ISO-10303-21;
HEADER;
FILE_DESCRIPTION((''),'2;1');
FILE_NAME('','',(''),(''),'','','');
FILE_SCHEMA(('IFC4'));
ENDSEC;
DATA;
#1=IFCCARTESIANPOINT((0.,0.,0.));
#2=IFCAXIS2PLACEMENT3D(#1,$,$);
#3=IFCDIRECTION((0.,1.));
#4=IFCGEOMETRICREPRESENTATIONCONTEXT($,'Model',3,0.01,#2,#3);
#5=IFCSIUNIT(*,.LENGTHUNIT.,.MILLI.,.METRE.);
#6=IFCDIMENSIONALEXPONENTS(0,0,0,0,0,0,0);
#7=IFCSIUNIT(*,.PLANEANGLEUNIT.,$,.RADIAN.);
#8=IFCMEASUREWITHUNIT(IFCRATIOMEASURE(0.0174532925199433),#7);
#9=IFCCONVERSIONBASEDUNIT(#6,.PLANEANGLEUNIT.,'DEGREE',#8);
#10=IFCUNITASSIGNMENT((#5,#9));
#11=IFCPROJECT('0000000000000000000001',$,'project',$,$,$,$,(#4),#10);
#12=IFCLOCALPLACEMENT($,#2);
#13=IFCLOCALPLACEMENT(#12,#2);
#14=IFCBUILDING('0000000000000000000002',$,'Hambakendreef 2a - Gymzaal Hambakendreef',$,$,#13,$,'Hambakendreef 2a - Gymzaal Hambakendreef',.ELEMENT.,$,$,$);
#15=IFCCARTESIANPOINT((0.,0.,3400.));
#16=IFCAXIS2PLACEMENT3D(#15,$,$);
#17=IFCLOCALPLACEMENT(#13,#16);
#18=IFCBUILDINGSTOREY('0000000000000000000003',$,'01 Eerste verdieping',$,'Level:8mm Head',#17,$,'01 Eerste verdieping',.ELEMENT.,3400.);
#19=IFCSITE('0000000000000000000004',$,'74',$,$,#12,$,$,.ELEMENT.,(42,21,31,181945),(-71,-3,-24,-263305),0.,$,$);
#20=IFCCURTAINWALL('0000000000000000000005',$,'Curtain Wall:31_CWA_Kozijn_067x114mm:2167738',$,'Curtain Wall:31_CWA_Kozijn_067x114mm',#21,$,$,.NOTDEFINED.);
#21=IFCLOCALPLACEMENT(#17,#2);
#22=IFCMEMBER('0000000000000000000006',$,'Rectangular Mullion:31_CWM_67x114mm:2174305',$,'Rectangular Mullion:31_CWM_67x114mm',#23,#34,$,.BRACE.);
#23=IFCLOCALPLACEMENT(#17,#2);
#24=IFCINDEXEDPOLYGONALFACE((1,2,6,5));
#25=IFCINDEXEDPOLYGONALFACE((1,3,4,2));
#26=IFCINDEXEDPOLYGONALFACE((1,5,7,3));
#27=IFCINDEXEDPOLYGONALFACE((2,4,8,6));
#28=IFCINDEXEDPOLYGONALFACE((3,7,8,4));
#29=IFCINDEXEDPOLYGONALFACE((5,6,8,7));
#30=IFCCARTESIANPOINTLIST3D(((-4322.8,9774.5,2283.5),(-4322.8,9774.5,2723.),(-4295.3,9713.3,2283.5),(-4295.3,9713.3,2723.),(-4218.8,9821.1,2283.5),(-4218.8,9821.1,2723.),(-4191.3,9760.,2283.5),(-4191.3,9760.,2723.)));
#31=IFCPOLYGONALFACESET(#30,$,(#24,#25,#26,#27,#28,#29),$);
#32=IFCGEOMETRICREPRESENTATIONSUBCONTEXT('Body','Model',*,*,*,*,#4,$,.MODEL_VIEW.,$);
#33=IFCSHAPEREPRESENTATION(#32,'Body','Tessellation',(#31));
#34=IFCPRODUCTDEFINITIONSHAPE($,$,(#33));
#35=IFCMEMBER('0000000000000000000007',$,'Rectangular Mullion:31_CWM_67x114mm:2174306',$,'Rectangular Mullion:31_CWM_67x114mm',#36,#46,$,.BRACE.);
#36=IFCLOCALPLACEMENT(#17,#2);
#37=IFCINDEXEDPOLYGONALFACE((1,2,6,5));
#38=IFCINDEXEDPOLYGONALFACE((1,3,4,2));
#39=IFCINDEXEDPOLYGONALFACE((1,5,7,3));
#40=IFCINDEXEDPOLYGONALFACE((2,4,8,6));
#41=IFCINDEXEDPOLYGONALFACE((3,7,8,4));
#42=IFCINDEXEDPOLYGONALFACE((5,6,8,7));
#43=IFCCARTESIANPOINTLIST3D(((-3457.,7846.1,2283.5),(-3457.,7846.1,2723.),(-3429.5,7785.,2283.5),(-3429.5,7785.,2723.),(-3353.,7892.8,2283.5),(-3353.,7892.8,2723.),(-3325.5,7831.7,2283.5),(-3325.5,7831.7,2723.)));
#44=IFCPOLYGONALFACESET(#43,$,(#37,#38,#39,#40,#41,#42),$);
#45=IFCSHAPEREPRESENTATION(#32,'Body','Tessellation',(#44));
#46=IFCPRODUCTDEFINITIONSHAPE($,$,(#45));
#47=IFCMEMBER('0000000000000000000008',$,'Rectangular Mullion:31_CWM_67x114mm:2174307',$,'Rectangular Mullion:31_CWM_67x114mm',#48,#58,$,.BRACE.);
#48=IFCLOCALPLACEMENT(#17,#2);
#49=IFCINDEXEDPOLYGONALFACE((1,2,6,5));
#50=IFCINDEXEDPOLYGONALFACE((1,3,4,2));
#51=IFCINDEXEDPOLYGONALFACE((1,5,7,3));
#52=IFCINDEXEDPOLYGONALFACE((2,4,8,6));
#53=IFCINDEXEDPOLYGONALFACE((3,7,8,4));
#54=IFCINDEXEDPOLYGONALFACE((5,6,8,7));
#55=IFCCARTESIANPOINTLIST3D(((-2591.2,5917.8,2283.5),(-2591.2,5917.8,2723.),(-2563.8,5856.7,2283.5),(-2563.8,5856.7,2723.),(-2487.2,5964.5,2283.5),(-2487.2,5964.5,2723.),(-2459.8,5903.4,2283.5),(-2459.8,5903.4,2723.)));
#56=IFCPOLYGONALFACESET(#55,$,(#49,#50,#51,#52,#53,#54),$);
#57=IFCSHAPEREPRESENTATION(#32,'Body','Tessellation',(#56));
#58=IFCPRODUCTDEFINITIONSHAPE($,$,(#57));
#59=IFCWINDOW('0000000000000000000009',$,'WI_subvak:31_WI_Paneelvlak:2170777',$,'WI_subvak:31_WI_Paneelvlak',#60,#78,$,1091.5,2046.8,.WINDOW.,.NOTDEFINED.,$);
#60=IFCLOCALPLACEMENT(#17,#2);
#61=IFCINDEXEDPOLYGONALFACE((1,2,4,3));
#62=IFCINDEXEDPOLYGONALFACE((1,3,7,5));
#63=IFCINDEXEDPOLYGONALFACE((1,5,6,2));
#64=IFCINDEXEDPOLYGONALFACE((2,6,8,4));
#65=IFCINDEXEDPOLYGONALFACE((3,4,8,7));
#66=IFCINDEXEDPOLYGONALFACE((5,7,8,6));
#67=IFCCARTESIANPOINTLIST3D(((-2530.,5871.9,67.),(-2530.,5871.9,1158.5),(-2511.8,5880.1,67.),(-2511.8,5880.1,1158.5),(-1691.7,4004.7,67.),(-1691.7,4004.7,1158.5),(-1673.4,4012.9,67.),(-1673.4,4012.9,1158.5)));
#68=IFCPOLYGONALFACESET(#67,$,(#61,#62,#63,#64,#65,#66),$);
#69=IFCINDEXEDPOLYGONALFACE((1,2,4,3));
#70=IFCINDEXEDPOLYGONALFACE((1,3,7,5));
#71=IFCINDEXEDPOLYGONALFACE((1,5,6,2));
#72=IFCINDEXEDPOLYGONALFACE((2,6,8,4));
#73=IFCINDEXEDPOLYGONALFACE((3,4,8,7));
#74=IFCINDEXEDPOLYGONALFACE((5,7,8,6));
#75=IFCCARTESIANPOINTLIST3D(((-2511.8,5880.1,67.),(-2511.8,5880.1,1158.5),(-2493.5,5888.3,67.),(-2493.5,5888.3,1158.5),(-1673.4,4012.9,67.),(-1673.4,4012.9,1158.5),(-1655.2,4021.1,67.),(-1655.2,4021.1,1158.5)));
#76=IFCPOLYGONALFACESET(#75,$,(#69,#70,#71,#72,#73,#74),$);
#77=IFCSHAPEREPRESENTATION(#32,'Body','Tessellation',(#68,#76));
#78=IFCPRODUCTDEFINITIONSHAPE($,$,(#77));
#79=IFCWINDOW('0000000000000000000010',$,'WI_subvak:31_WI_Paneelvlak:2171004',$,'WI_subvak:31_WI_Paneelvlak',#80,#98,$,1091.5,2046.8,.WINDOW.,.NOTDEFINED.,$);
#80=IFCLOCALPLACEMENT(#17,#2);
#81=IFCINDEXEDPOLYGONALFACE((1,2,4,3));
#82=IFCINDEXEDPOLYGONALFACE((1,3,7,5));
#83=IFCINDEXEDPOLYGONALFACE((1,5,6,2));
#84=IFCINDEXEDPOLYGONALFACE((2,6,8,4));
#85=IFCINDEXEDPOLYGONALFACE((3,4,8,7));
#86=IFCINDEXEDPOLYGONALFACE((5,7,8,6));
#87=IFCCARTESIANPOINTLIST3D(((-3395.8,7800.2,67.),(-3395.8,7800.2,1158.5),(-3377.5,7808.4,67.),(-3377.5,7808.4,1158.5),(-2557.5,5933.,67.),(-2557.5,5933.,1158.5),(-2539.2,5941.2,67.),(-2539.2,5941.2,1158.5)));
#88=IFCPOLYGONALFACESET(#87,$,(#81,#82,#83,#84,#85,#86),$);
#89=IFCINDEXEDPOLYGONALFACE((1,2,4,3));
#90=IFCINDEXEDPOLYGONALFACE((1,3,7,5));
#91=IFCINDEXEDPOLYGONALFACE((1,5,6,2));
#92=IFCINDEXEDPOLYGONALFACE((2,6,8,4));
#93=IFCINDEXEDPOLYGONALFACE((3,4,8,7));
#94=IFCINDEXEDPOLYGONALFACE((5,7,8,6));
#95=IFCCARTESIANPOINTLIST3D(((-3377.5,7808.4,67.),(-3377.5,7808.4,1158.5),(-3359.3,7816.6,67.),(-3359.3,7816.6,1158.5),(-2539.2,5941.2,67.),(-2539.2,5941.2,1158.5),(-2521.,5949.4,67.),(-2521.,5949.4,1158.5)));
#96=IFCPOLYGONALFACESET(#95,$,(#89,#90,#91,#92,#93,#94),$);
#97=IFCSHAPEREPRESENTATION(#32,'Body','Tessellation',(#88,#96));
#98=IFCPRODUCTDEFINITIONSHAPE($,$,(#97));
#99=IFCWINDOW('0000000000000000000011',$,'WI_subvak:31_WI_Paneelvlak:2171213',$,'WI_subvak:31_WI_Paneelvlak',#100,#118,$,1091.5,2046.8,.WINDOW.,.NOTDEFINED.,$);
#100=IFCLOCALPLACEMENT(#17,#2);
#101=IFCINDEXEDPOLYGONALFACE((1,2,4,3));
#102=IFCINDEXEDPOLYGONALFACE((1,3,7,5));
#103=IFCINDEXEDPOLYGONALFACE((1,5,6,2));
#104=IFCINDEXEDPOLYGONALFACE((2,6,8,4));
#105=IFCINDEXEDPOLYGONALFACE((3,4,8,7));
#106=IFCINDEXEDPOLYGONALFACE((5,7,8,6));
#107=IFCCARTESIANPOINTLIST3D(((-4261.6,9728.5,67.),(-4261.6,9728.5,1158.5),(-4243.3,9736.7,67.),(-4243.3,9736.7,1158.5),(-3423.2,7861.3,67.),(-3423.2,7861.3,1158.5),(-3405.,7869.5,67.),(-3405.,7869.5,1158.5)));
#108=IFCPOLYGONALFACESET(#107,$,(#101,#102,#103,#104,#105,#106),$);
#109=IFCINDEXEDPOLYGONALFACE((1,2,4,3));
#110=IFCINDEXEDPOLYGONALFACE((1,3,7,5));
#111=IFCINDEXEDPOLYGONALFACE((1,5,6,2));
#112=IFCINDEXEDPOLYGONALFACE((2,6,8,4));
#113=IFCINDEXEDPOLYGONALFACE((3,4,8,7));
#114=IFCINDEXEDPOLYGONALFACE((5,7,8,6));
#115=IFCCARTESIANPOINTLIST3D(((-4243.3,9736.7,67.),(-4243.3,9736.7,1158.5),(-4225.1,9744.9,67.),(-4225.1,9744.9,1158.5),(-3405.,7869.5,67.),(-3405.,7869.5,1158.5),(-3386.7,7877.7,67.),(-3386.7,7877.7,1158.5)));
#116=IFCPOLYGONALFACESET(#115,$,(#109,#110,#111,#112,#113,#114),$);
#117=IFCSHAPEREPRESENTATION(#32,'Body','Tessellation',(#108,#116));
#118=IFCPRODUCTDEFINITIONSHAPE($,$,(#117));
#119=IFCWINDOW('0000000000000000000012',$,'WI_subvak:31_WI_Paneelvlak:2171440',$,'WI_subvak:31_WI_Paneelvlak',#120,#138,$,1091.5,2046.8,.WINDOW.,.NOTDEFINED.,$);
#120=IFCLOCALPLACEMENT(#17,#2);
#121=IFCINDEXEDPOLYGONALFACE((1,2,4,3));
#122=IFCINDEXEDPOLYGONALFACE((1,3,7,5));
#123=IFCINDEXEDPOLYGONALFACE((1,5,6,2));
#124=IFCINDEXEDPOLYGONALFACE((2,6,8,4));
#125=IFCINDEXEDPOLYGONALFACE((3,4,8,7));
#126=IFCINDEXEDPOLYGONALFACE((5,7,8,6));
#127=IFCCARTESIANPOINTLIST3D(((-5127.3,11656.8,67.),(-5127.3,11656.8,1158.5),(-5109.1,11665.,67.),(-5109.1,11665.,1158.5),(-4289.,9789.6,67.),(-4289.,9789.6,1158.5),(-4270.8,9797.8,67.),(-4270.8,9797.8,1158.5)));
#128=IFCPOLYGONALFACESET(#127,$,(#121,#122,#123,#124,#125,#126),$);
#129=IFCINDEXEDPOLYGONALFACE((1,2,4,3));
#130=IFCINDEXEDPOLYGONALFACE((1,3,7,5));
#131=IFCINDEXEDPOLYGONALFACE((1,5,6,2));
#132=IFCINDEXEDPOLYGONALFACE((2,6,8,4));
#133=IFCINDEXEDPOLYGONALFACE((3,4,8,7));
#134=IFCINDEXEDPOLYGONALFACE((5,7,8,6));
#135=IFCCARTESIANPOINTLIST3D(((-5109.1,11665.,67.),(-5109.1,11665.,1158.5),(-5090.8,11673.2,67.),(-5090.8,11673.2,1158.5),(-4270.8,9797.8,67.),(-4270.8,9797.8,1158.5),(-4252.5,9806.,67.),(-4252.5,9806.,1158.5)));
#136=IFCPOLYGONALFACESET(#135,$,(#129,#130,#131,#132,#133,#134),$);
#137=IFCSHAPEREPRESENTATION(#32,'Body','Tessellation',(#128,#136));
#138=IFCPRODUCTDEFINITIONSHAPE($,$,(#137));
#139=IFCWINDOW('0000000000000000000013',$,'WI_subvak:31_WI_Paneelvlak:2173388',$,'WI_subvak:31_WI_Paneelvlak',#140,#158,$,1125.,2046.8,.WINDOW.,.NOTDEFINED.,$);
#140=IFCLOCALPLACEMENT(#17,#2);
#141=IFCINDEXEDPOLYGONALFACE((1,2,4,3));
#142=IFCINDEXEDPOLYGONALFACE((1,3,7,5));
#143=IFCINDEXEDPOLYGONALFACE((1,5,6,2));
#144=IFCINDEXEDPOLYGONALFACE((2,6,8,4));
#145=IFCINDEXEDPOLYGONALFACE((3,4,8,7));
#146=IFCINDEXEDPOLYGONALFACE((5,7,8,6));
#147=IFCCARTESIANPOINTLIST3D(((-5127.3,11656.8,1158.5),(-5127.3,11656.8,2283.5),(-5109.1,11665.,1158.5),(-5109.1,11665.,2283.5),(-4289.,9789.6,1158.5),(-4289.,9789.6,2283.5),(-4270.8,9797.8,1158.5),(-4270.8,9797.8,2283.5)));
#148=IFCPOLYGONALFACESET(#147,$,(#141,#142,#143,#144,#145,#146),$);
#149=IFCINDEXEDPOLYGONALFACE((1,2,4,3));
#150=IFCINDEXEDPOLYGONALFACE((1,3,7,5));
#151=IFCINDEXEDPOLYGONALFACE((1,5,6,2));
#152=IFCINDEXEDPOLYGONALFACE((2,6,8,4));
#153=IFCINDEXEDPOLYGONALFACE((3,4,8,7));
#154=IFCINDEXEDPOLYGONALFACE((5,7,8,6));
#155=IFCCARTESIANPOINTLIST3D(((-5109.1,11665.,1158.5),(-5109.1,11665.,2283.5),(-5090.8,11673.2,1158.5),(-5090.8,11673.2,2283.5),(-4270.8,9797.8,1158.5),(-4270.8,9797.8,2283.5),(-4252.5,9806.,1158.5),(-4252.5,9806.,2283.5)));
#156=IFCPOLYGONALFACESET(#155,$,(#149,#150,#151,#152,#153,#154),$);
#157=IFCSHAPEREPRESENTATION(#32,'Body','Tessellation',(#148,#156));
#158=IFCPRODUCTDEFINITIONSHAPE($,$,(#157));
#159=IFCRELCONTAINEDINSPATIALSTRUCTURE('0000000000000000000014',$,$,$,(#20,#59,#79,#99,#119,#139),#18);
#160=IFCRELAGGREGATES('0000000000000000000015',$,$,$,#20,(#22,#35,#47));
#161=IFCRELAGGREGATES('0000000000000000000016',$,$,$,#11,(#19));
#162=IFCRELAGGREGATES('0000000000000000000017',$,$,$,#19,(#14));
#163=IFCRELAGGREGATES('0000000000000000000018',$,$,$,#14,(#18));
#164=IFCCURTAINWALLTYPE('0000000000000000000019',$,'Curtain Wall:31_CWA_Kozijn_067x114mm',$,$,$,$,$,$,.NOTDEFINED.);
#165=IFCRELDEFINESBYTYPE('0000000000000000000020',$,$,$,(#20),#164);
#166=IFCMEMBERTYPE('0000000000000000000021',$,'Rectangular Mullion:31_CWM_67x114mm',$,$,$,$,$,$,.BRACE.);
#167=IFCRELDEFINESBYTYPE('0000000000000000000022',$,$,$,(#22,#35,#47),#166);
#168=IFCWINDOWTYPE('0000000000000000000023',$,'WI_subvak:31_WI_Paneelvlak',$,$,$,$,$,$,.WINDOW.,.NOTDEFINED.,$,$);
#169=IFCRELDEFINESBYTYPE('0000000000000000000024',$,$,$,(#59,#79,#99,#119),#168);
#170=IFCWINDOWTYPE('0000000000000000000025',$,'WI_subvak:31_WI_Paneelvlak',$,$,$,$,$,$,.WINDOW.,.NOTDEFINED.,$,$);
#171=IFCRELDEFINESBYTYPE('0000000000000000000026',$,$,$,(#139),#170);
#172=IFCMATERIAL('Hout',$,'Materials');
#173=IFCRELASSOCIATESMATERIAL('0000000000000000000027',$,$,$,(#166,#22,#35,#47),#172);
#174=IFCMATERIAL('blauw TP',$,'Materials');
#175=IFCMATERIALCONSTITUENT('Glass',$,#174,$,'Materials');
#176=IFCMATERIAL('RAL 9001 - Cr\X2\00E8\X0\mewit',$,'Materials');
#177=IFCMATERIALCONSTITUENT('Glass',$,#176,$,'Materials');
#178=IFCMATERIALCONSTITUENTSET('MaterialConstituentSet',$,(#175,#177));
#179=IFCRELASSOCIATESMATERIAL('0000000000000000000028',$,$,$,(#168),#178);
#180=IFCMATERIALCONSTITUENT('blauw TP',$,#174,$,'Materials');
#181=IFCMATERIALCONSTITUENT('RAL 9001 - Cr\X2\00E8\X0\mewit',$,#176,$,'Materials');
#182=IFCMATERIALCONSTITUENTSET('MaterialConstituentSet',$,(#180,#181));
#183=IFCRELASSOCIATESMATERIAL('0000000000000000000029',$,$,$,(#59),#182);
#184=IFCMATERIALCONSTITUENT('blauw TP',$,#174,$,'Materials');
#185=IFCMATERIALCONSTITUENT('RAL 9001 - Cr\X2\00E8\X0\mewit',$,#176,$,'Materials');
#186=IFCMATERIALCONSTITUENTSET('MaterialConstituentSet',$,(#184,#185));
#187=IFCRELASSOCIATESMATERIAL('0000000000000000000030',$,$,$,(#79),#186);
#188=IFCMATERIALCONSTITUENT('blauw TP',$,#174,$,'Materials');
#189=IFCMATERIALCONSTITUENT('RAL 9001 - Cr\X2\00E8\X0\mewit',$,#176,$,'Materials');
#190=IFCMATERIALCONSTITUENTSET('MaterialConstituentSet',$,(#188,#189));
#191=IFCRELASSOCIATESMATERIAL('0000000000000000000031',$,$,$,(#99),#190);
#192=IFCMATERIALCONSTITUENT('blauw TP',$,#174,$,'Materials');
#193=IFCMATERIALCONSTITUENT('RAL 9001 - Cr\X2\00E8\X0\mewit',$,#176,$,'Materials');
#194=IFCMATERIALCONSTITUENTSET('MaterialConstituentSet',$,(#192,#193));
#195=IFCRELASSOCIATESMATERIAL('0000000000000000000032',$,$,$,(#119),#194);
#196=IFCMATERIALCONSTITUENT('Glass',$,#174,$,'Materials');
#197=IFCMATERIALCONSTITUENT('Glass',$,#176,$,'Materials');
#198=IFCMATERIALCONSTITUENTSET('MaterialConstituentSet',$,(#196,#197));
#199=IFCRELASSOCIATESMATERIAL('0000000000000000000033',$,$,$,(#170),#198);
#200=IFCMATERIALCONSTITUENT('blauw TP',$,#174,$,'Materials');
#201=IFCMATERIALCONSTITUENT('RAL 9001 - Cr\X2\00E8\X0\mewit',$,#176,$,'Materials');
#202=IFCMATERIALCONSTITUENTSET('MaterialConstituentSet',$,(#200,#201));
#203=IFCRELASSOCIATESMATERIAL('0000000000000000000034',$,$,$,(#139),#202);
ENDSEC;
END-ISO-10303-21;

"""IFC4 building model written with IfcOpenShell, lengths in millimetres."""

from ifc_helpers import new_model, entity, si_unit, converted_unit, direction, frame, origin, place, context, subcontext, project, spatial, indexed_curve, outline, extrude, source, transform, mapped, material, constituent, constituent_set, type_object, type_shapes, element, aggregate, save


model = new_model("IFC4")

# Units and contexts
model_context = context("Model", 3, precision=0.01, world=origin(), true_north=direction((0.0, 1.0)))
body_context = subcontext(model_context, "Body", "Model", "MODEL_VIEW")
ifc_project = project(units=[si_unit("LENGTHUNIT", "METRE", prefix="MILLI"), converted_unit("PLANEANGLEUNIT", "DEGREE", entity("IfcRatioMeasure", 0.0174532925199433), si_unit("PLANEANGLEUNIT", "RADIAN"), dimensions=[0, 0, 0, 0, 0, 0, 0])], contexts=[model_context])

# Site, building, storey
site_placement = place(None, origin())
site = spatial("IfcSite", under=ifc_project, at=site_placement, Name="74", CompositionType="ELEMENT", RefLatitude=(42, 21, 31, 181945), RefLongitude=(-71, -3, -24, -263305), RefElevation=0.0)
building_placement = place(site_placement, origin())
building = spatial("IfcBuilding", under=site, at=building_placement, Name="Hambakendreef 2a - Gymzaal Hambakendreef", LongName="Hambakendreef 2a - Gymzaal Hambakendreef", CompositionType="ELEMENT")
storey_placement = place(building_placement, frame((0.0, 0.0, 3400.0)))
storey = spatial("IfcBuildingStorey", under=building, at=storey_placement, Name="01 Eerste verdieping", ObjectType="Level:8mm Head", LongName="01 Eerste verdieping", CompositionType="ELEMENT", Elevation=3400.0)

# Curtain wall, members
curtain_wall_type = type_object("IfcCurtainWallType", Name="Curtain Wall:31_CWA_Kozijn_067x114mm", PredefinedType="NOTDEFINED")
curtain_wall_placement = place(storey_placement, frame((0.0, 0.0, -3400.0)))
curtain_wall = element("IfcCurtainWall", 1, at=curtain_wall_placement, inside=storey, type_object=curtain_wall_type, Name="Curtain Wall:31_CWA_Kozijn_067x114mm:2167738", ObjectType="Curtain Wall:31_CWA_Kozijn_067x114mm", PredefinedType="NOTDEFINED")
ifc_material_1 = material(Name="Hout", Category="Materials")
member_type_1 = type_object("IfcMemberType", Name="Rectangular Mullion:31_CWM_67x114mm", PredefinedType="BRACE", material=ifc_material_1)
shared_shape_1 = source(origin(), body_context, "Body", "SweptSolid", [
    extrude(outline(indexed_curve([(-57.0, -33.5), (57.0, -33.5), (57.0, 33.5), (-57.0, 33.5), (-57.0, -33.5)], self_intersect=False)), frame((0.0, 0.0, -439.5), z_axis=(0.0, 0.0, 1.0), x_axis=(0.0, -1.0, 0.0)), (0.0, 0.0, 1.0), 439.5),
])
type_shapes(member_type_1, [shared_shape_1])
member_1_placement = place(storey_placement, frame((-4257.0, 9767.2, 2283.5), z_axis=(0.0, 0.0, -1.0), x_axis=(0.40959, -0.91227, 0.0)))
member_1 = element("IfcMember", 2, at=member_1_placement, type_object=member_type_1, material=ifc_material_1, Name="Rectangular Mullion:31_CWM_67x114mm:2174305", ObjectType="Rectangular Mullion:31_CWM_67x114mm", PredefinedType="BRACE", context=body_context, shape_type="MappedRepresentation", body=[
    mapped(shared_shape_1, transform((0.0, 0.0, 0.0), scale=1.0)),
])
member_2_placement = place(storey_placement, frame((-3391.3, 7838.9, 2283.5), z_axis=(0.0, 0.0, -1.0), x_axis=(0.40959, -0.91227, 0.0)))
member_2 = element("IfcMember", 3, at=member_2_placement, type_object=member_type_1, material=ifc_material_1, Name="Rectangular Mullion:31_CWM_67x114mm:2174306", ObjectType="Rectangular Mullion:31_CWM_67x114mm", PredefinedType="BRACE", context=body_context, shape_type="MappedRepresentation", body=[
    mapped(shared_shape_1, transform((0.0, 0.0, 0.0), scale=1.0)),
])
member_3_placement = place(storey_placement, frame((-2525.5, 5910.6, 2283.5), z_axis=(0.0, 0.0, -1.0), x_axis=(0.40959, -0.91227, 0.0)))
member_3 = element("IfcMember", 4, at=member_3_placement, type_object=member_type_1, material=ifc_material_1, Name="Rectangular Mullion:31_CWM_67x114mm:2174307", ObjectType="Rectangular Mullion:31_CWM_67x114mm", PredefinedType="BRACE", context=body_context, shape_type="MappedRepresentation", body=[
    mapped(shared_shape_1, transform((0.0, 0.0, 0.0), scale=1.0)),
])
aggregate(curtain_wall, [member_1, member_2, member_3])

# Windows
ifc_material_2 = material(Name="blauw TP", Category="Materials")
ifc_constituent_1 = constituent(ifc_material_2, Name="blauw TP", Category="Materials")
ifc_material_3 = material(Name="RAL 9001 - Crèmewit", Category="Materials")
ifc_constituent_2 = constituent(ifc_material_3, Name="RAL 9001 - Crèmewit", Category="Materials")
ifc_constituent_set_1 = constituent_set(constituents=[ifc_constituent_1, ifc_constituent_2], Name="MaterialConstituentSet")
ifc_constituent_3 = constituent(ifc_material_2, Name="Glass", Category="Materials")
ifc_constituent_4 = constituent(ifc_material_3, Name="Glass", Category="Materials")
ifc_constituent_set_2 = constituent_set(constituents=[ifc_constituent_3, ifc_constituent_4], Name="MaterialConstituentSet")
window_type_1 = type_object("IfcWindowType", Name="WI_subvak:31_WI_Paneelvlak", PartitioningType="NOTDEFINED", PredefinedType="WINDOW", material=ifc_constituent_set_2)
shared_shape_2 = source(origin(), body_context, "Body", "SweptSolid", [
    extrude(outline(indexed_curve([(-1023.4, -10.0), (1023.4, -10.0), (1023.4, 10.0), (-1023.4, 10.0), (-1023.4, -10.0)], self_intersect=False)), frame((0.0, -10.0, 0.0)), (0.0, 0.0, 1.0), 1091.5),
    extrude(outline(indexed_curve([(-1023.4, -10.0), (1023.4, -10.0), (1023.4, 10.0), (-1023.4, 10.0), (-1023.4, -10.0)], self_intersect=False)), frame((0.0, 10.0, 0.0)), (0.0, 0.0, 1.0), 1091.5),
])
type_shapes(window_type_1, [shared_shape_2])
window_1_placement = place(storey_placement, frame((-2092.6, 4946.5, 67.0), z_axis=(0.0, 0.0, 1.0), x_axis=(0.40959, -0.91227, 0.0)))
element("IfcWindow", 5, at=window_1_placement, inside=storey, type_object=window_type_1, material=ifc_constituent_set_1, Name="WI_subvak:31_WI_Paneelvlak:2170777", ObjectType="WI_subvak:31_WI_Paneelvlak", OverallHeight=1091.5, OverallWidth=2046.8, PartitioningType="NOTDEFINED", PredefinedType="WINDOW", context=body_context, shape_type="MappedRepresentation", body=[
    mapped(shared_shape_2, transform((0.0, 0.0, 0.0), scale=1.0)),
])
ifc_constituent_5 = constituent(ifc_material_2, Name="blauw TP", Category="Materials")
ifc_constituent_6 = constituent(ifc_material_3, Name="RAL 9001 - Crèmewit", Category="Materials")
ifc_constituent_set_3 = constituent_set(constituents=[ifc_constituent_5, ifc_constituent_6], Name="MaterialConstituentSet")
window_2_placement = place(storey_placement, frame((-2958.4, 6874.8, 67.0), z_axis=(0.0, 0.0, 1.0), x_axis=(0.40959, -0.91227, 0.0)))
element("IfcWindow", 6, at=window_2_placement, inside=storey, type_object=window_type_1, material=ifc_constituent_set_3, Name="WI_subvak:31_WI_Paneelvlak:2171004", ObjectType="WI_subvak:31_WI_Paneelvlak", OverallHeight=1091.5, OverallWidth=2046.8, PartitioningType="NOTDEFINED", PredefinedType="WINDOW", context=body_context, shape_type="MappedRepresentation", body=[
    mapped(shared_shape_2, transform((0.0, 0.0, 0.0), scale=1.0)),
])
ifc_constituent_7 = constituent(ifc_material_2, Name="blauw TP", Category="Materials")
ifc_constituent_8 = constituent(ifc_material_3, Name="RAL 9001 - Crèmewit", Category="Materials")
ifc_constituent_set_4 = constituent_set(constituents=[ifc_constituent_7, ifc_constituent_8], Name="MaterialConstituentSet")
window_3_placement = place(storey_placement, frame((-3824.2, 8803.1, 67.0), z_axis=(0.0, 0.0, 1.0), x_axis=(0.40959, -0.91227, 0.0)))
element("IfcWindow", 7, at=window_3_placement, inside=storey, type_object=window_type_1, material=ifc_constituent_set_4, Name="WI_subvak:31_WI_Paneelvlak:2171213", ObjectType="WI_subvak:31_WI_Paneelvlak", OverallHeight=1091.5, OverallWidth=2046.8, PartitioningType="NOTDEFINED", PredefinedType="WINDOW", context=body_context, shape_type="MappedRepresentation", body=[
    mapped(shared_shape_2, transform((0.0, 0.0, 0.0), scale=1.0)),
])
ifc_constituent_9 = constituent(ifc_material_2, Name="blauw TP", Category="Materials")
ifc_constituent_10 = constituent(ifc_material_3, Name="RAL 9001 - Crèmewit", Category="Materials")
ifc_constituent_set_5 = constituent_set(constituents=[ifc_constituent_9, ifc_constituent_10], Name="MaterialConstituentSet")
window_4_placement = place(storey_placement, frame((-4689.9, 10731.4, 67.0), z_axis=(0.0, 0.0, 1.0), x_axis=(0.40959, -0.91227, 0.0)))
element("IfcWindow", 8, at=window_4_placement, inside=storey, type_object=window_type_1, material=ifc_constituent_set_5, Name="WI_subvak:31_WI_Paneelvlak:2171440", ObjectType="WI_subvak:31_WI_Paneelvlak", OverallHeight=1091.5, OverallWidth=2046.8, PartitioningType="NOTDEFINED", PredefinedType="WINDOW", context=body_context, shape_type="MappedRepresentation", body=[
    mapped(shared_shape_2, transform((0.0, 0.0, 0.0), scale=1.0)),
])
ifc_constituent_11 = constituent(ifc_material_2, Name="blauw TP", Category="Materials")
ifc_constituent_12 = constituent(ifc_material_3, Name="RAL 9001 - Crèmewit", Category="Materials")
ifc_constituent_set_6 = constituent_set(constituents=[ifc_constituent_11, ifc_constituent_12], Name="MaterialConstituentSet")
ifc_constituent_13 = constituent(ifc_material_2, Name="Glass", Category="Materials")
ifc_constituent_14 = constituent(ifc_material_3, Name="Glass", Category="Materials")
ifc_constituent_set_7 = constituent_set(constituents=[ifc_constituent_13, ifc_constituent_14], Name="MaterialConstituentSet")
window_type_2 = type_object("IfcWindowType", Name="WI_subvak:31_WI_Paneelvlak", PartitioningType="NOTDEFINED", PredefinedType="WINDOW", material=ifc_constituent_set_7)
shared_shape_3 = source(origin(), body_context, "Body", "SweptSolid", [
    extrude(outline(indexed_curve([(-1023.4, -10.0), (1023.4, -10.0), (1023.4, 10.0), (-1023.4, 10.0), (-1023.4, -10.0)], self_intersect=False)), frame((0.0, -10.0, 0.0)), (0.0, 0.0, 1.0), 1125.0),
    extrude(outline(indexed_curve([(-1023.4, -10.0), (1023.4, -10.0), (1023.4, 10.0), (-1023.4, 10.0), (-1023.4, -10.0)], self_intersect=False)), frame((0.0, 10.0, 0.0)), (0.0, 0.0, 1.0), 1125.0),
])
type_shapes(window_type_2, [shared_shape_3])
window_5_placement = place(storey_placement, frame((-4689.9, 10731.4, 1158.5), z_axis=(0.0, 0.0, 1.0), x_axis=(0.40959, -0.91227, 0.0)))
element("IfcWindow", 9, at=window_5_placement, inside=storey, type_object=window_type_2, material=ifc_constituent_set_6, Name="WI_subvak:31_WI_Paneelvlak:2173388", ObjectType="WI_subvak:31_WI_Paneelvlak", OverallHeight=1125.0, OverallWidth=2046.8, PartitioningType="NOTDEFINED", PredefinedType="WINDOW", context=body_context, shape_type="MappedRepresentation", body=[
    mapped(shared_shape_3, transform((0.0, 0.0, 0.0), scale=1.0)),
])

save(model, "model.ifc")
